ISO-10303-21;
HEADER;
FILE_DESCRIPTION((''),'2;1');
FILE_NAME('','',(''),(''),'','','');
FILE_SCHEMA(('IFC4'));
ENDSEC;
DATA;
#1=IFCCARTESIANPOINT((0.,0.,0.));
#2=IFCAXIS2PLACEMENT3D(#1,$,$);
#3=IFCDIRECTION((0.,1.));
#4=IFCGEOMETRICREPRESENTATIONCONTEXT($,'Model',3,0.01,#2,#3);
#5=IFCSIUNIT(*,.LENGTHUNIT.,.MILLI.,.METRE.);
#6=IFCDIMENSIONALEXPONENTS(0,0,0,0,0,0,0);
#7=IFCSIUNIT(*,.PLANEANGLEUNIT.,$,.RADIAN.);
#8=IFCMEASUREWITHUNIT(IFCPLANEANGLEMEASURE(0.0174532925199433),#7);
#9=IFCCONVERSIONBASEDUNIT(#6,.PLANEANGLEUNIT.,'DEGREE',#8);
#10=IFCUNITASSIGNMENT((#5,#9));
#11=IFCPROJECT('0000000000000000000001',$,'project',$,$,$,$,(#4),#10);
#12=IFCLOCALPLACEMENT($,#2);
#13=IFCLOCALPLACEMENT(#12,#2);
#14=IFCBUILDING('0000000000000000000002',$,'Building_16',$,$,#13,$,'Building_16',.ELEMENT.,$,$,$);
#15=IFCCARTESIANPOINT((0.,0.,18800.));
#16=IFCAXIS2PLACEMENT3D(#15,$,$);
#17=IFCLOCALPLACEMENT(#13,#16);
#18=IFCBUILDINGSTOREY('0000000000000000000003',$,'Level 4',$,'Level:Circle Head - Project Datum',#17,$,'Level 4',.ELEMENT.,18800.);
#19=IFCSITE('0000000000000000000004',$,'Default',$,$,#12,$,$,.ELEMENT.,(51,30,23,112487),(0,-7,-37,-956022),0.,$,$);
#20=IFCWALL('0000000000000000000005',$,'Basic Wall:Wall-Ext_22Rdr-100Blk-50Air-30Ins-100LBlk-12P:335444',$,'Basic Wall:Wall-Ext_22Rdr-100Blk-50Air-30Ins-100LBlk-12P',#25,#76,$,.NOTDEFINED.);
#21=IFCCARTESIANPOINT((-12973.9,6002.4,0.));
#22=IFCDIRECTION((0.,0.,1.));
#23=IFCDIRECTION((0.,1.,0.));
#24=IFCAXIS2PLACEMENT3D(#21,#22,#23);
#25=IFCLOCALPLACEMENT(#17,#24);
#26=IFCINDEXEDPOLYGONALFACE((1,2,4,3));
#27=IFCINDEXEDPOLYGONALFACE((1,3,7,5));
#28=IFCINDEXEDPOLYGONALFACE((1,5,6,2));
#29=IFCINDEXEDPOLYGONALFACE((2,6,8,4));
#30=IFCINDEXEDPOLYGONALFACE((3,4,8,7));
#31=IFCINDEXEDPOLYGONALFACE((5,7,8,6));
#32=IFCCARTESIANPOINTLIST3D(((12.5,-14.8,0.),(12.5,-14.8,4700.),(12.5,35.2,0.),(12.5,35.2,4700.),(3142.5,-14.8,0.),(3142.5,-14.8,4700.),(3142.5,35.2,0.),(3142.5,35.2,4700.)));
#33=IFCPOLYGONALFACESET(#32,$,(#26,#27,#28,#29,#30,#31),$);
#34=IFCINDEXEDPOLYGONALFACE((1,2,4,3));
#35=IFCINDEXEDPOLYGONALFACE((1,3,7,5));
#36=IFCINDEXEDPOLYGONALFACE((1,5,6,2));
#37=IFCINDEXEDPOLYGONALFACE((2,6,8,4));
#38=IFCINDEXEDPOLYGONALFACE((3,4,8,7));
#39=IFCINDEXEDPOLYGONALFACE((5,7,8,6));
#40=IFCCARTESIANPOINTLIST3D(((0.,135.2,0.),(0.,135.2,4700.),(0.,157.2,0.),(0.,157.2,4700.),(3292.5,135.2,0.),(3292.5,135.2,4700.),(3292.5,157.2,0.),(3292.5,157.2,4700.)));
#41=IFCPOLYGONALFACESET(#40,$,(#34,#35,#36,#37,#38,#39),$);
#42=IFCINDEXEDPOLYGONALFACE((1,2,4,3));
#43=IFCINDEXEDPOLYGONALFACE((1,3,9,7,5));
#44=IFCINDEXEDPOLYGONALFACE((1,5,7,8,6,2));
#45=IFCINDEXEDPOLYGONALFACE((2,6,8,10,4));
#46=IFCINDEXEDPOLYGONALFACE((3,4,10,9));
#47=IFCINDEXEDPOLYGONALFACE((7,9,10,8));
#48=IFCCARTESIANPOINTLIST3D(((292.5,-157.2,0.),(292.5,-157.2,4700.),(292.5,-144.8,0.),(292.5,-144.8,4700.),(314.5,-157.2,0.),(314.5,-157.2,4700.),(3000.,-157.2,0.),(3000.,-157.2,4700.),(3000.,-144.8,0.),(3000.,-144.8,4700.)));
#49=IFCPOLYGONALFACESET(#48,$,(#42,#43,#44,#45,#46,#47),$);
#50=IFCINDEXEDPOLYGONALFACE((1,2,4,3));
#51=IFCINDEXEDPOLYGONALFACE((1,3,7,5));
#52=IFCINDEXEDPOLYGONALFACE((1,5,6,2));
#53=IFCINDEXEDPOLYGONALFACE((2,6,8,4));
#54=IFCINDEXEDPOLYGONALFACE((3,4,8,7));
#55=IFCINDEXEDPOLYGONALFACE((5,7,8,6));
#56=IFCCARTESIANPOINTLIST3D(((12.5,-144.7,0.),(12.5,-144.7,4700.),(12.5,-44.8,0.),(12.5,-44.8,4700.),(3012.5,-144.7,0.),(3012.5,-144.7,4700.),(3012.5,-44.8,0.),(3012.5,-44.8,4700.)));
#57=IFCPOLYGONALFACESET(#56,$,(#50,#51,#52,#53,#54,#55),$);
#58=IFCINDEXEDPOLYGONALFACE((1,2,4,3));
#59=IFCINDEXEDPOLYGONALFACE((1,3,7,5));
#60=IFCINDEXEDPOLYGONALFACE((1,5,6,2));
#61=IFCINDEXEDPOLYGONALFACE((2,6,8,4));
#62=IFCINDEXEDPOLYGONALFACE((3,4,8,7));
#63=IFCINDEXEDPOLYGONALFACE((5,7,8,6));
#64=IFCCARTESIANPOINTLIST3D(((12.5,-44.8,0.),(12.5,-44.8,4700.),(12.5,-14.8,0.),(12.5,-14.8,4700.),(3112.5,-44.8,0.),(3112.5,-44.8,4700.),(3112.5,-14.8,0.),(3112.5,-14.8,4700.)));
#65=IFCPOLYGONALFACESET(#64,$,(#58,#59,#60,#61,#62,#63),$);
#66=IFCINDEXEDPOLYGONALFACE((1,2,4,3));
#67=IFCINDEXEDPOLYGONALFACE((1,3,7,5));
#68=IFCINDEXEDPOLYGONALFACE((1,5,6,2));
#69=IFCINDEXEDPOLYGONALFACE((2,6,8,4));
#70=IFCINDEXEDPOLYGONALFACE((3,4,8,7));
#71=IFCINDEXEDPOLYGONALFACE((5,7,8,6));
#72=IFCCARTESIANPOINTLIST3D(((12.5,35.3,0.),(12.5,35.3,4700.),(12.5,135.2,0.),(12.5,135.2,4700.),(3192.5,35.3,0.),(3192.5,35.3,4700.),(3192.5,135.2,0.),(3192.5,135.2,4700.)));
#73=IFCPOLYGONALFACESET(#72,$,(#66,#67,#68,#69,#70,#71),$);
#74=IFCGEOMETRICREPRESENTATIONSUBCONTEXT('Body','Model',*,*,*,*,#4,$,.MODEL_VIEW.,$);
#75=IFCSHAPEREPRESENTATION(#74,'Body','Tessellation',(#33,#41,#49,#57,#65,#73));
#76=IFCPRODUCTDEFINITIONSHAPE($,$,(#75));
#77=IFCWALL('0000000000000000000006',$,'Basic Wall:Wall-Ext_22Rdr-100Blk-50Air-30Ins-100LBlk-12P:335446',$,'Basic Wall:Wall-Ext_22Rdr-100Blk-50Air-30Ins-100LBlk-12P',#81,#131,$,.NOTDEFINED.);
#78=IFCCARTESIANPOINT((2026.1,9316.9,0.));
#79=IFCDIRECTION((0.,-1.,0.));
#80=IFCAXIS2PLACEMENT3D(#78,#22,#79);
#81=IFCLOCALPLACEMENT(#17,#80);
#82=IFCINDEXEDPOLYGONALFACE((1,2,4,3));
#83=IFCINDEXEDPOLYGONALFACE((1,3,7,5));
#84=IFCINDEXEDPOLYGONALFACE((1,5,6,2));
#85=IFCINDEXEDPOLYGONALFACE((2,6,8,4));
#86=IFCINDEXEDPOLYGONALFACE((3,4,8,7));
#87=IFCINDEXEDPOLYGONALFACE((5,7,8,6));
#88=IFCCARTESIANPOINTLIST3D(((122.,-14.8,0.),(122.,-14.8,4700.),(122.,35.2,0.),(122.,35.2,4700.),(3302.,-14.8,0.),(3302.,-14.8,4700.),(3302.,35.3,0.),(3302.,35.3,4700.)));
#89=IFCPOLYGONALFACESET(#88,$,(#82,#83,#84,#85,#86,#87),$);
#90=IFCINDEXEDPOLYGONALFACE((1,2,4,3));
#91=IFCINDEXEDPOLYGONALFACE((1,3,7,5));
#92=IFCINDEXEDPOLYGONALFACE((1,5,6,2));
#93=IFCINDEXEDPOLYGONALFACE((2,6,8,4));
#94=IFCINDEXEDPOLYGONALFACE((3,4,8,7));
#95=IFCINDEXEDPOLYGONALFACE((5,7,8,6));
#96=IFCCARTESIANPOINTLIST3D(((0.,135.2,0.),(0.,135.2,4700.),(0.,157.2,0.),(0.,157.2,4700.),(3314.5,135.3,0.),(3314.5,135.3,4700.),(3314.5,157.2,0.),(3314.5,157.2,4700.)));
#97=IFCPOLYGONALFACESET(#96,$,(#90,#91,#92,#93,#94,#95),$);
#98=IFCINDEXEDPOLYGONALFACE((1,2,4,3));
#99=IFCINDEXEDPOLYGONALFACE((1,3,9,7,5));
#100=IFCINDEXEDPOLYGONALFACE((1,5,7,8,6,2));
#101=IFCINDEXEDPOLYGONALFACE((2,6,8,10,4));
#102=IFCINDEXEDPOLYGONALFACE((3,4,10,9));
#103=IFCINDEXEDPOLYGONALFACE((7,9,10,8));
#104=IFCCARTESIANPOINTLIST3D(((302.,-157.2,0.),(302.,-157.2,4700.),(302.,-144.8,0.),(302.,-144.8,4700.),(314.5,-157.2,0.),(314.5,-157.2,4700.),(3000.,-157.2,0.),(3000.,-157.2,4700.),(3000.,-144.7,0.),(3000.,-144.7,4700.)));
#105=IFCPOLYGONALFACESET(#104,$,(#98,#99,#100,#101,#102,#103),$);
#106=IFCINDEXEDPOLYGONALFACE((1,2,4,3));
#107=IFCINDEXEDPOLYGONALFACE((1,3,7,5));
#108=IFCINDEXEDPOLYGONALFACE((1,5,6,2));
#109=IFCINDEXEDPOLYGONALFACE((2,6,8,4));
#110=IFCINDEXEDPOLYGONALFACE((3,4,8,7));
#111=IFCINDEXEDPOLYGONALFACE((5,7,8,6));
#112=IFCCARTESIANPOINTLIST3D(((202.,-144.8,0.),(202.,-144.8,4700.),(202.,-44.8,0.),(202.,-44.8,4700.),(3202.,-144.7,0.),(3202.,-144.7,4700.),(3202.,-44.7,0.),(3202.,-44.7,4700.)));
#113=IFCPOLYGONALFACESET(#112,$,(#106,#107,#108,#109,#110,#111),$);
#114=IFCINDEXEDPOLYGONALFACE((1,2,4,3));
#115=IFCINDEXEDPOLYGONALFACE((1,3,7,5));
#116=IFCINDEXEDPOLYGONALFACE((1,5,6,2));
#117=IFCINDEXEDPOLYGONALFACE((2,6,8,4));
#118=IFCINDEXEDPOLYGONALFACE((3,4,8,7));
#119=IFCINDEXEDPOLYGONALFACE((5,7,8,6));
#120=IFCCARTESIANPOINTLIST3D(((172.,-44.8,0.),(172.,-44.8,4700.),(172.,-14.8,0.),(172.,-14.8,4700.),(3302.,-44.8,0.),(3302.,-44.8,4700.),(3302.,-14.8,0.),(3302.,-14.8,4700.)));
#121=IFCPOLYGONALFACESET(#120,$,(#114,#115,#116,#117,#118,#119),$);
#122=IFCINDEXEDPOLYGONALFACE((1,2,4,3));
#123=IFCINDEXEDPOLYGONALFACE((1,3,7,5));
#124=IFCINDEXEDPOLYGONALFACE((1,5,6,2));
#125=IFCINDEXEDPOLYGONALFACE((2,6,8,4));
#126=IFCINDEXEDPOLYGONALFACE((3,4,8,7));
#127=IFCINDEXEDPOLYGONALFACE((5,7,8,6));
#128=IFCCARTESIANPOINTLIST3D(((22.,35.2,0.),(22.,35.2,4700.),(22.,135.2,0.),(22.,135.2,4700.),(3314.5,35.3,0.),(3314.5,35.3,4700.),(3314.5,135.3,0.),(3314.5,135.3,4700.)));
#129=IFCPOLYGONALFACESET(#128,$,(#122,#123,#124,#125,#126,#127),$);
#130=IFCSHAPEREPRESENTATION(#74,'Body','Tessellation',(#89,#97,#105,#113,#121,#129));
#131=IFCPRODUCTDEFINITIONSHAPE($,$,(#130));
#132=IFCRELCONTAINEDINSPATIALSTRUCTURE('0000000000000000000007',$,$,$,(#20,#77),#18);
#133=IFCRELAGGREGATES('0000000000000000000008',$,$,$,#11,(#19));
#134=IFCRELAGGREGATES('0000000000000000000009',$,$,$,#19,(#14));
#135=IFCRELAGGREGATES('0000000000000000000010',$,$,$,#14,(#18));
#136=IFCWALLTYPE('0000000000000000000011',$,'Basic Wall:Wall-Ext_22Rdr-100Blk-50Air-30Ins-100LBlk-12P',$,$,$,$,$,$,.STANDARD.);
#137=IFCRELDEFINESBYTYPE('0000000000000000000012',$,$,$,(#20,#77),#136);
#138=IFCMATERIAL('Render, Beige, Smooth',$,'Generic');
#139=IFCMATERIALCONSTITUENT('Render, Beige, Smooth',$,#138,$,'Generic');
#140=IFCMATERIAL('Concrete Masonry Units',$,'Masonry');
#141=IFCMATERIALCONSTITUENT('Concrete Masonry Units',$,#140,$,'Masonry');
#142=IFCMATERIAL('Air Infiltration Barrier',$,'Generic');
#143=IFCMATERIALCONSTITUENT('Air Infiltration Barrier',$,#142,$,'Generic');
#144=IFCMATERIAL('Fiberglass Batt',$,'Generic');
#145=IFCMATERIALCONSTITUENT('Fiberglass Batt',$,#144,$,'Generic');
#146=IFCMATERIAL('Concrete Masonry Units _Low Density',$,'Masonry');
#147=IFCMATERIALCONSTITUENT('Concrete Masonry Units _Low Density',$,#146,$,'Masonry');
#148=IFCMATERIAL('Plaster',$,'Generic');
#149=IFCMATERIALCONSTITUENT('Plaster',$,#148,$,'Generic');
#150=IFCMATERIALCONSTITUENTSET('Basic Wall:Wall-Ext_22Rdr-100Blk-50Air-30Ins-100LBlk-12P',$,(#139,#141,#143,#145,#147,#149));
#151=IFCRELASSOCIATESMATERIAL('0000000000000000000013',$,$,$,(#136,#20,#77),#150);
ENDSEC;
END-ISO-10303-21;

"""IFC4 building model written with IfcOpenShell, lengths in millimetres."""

from ifc_helpers import new_model, entity, si_unit, converted_unit, direction, frame, origin, place, context, subcontext, project, spatial, indexed_curve, outline, extrude, material, constituent, constituent_set, type_object, element, save


model = new_model("IFC4")

# Units and contexts
model_context = context("Model", 3, precision=0.01, world=origin(), true_north=direction((0.0, 1.0)))
body_context = subcontext(model_context, "Body", "Model", "MODEL_VIEW")
ifc_project = project(units=[si_unit("LENGTHUNIT", "METRE", prefix="MILLI"), converted_unit("PLANEANGLEUNIT", "DEGREE", entity("IfcPlaneAngleMeasure", 0.0174532925199433), si_unit("PLANEANGLEUNIT", "RADIAN"), dimensions=[0, 0, 0, 0, 0, 0, 0])], contexts=[model_context])

# Site, building, storey
site_placement = place(None, origin())
site = spatial("IfcSite", under=ifc_project, at=site_placement, Name="Default", CompositionType="ELEMENT", RefLatitude=(51, 30, 23, 112487), RefLongitude=(0, -7, -37, -956022), RefElevation=0.0)
building_placement = place(site_placement, origin())
building = spatial("IfcBuilding", under=site, at=building_placement, Name="Building_16", LongName="Building_16", CompositionType="ELEMENT")
storey_placement = place(building_placement, frame((0.0, 0.0, 18800.0)))
storey = spatial("IfcBuildingStorey", under=building, at=storey_placement, Name="Level 4", ObjectType="Level:Circle Head - Project Datum", LongName="Level 4", CompositionType="ELEMENT", Elevation=18800.0)

# Shared definitions
ifc_material_1 = material(Name="Render, Beige, Smooth", Category="Generic")
ifc_constituent_1 = constituent(ifc_material_1, Name="Render, Beige, Smooth", Category="Generic")
ifc_material_2 = material(Name="Concrete Masonry Units", Category="Masonry")
ifc_constituent_2 = constituent(ifc_material_2, Name="Concrete Masonry Units", Category="Masonry")
ifc_material_3 = material(Name="Air Infiltration Barrier", Category="Generic")
ifc_constituent_3 = constituent(ifc_material_3, Name="Air Infiltration Barrier", Category="Generic")
ifc_material_4 = material(Name="Fiberglass Batt", Category="Generic")
ifc_constituent_4 = constituent(ifc_material_4, Name="Fiberglass Batt", Category="Generic")
ifc_material_5 = material(Name="Concrete Masonry Units _Low Density", Category="Masonry")
ifc_constituent_5 = constituent(ifc_material_5, Name="Concrete Masonry Units _Low Density", Category="Masonry")
ifc_material_6 = material(Name="Plaster", Category="Generic")
ifc_constituent_6 = constituent(ifc_material_6, Name="Plaster", Category="Generic")
ifc_constituent_set_1 = constituent_set(constituents=[ifc_constituent_1, ifc_constituent_2, ifc_constituent_3, ifc_constituent_4, ifc_constituent_5, ifc_constituent_6], Name="Basic Wall:Wall-Ext_22Rdr-100Blk-50Air-30Ins-100LBlk-12P")
wall_type_1 = type_object("IfcWallType", Name="Basic Wall:Wall-Ext_22Rdr-100Blk-50Air-30Ins-100LBlk-12P", PredefinedType="STANDARD", material=ifc_constituent_set_1)

# Wall
wall_1_placement = place(storey_placement, frame((-12973.9, 6002.4, 0.0), z_axis=(0.0, 0.0, 1.0), x_axis=(0.0, 1.0, 0.0)))
element("IfcWall", 1, at=wall_1_placement, inside=storey, type_object=wall_type_1, material=ifc_constituent_set_1, Name="Basic Wall:Wall-Ext_22Rdr-100Blk-50Air-30Ins-100LBlk-12P:335444", ObjectType="Basic Wall:Wall-Ext_22Rdr-100Blk-50Air-30Ins-100LBlk-12P", PredefinedType="NOTDEFINED", context=body_context, shape_type="SweptSolid", body=[
    extrude(outline(indexed_curve([(-1565.0, -25.0), (1565.0, -25.0), (1565.0, 25.0), (-1565.0, 25.0), (-1565.0, -25.0)], self_intersect=False)), frame((1577.5, 10.2, 0.0)), (0.0, 0.0, 1.0), 4700.0),
    extrude(outline(indexed_curve([(-11.0, -1646.2), (11.0, -1646.2), (11.0, 1646.3), (-11.0, 1646.3), (-11.0, -1646.2)], self_intersect=False)), frame((1646.2, 146.3, 0.0), z_axis=(0.0, 0.0, 1.0), x_axis=(0.0, -1.0, 0.0)), (0.0, 0.0, 1.0), 4700.0),
    extrude(outline(indexed_curve([(-1065.4, -5.0), (1620.1, -5.0), (1620.1, 7.5), (-1087.4, 7.5), (-1087.4, -5.0), (-1065.4, -5.0)], self_intersect=False)), frame((1379.9, -152.2, 0.0)), (0.0, 0.0, 1.0), 4700.0),
    extrude(outline(indexed_curve([(-1500.0, -50.0), (1500.0, -50.0), (1500.0, 50.0), (-1500.0, 50.0), (-1500.0, -50.0)], self_intersect=False)), frame((1512.5, -94.8, 0.0)), (0.0, 0.0, 1.0), 4700.0),
    extrude(outline(indexed_curve([(-1550.0, -15.0), (1550.0, -15.0), (1550.0, 15.0), (-1550.0, 15.0), (-1550.0, -15.0)], self_intersect=False)), frame((1562.5, -29.8, 0.0)), (0.0, 0.0, 1.0), 4700.0),
    extrude(outline(indexed_curve([(-1590.0, -50.0), (1590.0, -50.0), (1590.0, 50.0), (-1590.0, 50.0), (-1590.0, -50.0)], self_intersect=False)), frame((1602.5, 85.3, 0.0)), (0.0, 0.0, 1.0), 4700.0),
])

# Wall
wall_2_placement = place(storey_placement, frame((2026.1, 9316.9, 0.0), z_axis=(0.0, 0.0, 1.0), x_axis=(0.0, -1.0, 0.0)))
element("IfcWall", 2, at=wall_2_placement, inside=storey, type_object=wall_type_1, material=ifc_constituent_set_1, Name="Basic Wall:Wall-Ext_22Rdr-100Blk-50Air-30Ins-100LBlk-12P:335446", ObjectType="Basic Wall:Wall-Ext_22Rdr-100Blk-50Air-30Ins-100LBlk-12P", PredefinedType="NOTDEFINED", context=body_context, shape_type="SweptSolid", body=[
    extrude(outline(indexed_curve([(-1590.0, -25.0), (1590.0, -25.0), (1590.0, 25.0), (-1590.0, 25.0), (-1590.0, -25.0)], self_intersect=False)), frame((1712.0, 10.3, 0.0)), (0.0, 0.0, 1.0), 4700.0),
    extrude(outline(indexed_curve([(-11.0, -1657.3), (11.0, -1657.3), (11.0, 1657.3), (-11.0, 1657.3), (-11.0, -1657.3)], self_intersect=False)), frame((1657.3, 146.2, 0.0), z_axis=(0.0, 0.0, 1.0), x_axis=(0.0, -1.0, 0.0)), (0.0, 0.0, 1.0), 4700.0),
    extrude(outline(indexed_curve([(-1069.2, -5.0), (1616.3, -5.0), (1616.3, 7.5), (-1081.7, 7.5), (-1081.7, -5.0), (-1069.2, -5.0)], self_intersect=False)), frame((1383.7, -152.2, 0.0)), (0.0, 0.0, 1.0), 4700.0),
    extrude(outline(indexed_curve([(-1500.0, -50.0), (1500.0, -50.0), (1500.0, 50.0), (-1500.0, 50.0), (-1500.0, -50.0)], self_intersect=False)), frame((1702.0, -94.8, 0.0)), (0.0, 0.0, 1.0), 4700.0),
    extrude(outline(indexed_curve([(-1565.0, -15.0), (1565.0, -15.0), (1565.0, 15.0), (-1565.0, 15.0), (-1565.0, -15.0)], self_intersect=False)), frame((1737.0, -29.8, 0.0)), (0.0, 0.0, 1.0), 4700.0),
    extrude(outline(indexed_curve([(-1646.3, -50.0), (1646.2, -50.0), (1646.2, 50.0), (-1646.3, 50.0), (-1646.3, -50.0)], self_intersect=False)), frame((1668.3, 85.2, 0.0)), (0.0, 0.0, 1.0), 4700.0),
])

save(model, "model.ifc")
